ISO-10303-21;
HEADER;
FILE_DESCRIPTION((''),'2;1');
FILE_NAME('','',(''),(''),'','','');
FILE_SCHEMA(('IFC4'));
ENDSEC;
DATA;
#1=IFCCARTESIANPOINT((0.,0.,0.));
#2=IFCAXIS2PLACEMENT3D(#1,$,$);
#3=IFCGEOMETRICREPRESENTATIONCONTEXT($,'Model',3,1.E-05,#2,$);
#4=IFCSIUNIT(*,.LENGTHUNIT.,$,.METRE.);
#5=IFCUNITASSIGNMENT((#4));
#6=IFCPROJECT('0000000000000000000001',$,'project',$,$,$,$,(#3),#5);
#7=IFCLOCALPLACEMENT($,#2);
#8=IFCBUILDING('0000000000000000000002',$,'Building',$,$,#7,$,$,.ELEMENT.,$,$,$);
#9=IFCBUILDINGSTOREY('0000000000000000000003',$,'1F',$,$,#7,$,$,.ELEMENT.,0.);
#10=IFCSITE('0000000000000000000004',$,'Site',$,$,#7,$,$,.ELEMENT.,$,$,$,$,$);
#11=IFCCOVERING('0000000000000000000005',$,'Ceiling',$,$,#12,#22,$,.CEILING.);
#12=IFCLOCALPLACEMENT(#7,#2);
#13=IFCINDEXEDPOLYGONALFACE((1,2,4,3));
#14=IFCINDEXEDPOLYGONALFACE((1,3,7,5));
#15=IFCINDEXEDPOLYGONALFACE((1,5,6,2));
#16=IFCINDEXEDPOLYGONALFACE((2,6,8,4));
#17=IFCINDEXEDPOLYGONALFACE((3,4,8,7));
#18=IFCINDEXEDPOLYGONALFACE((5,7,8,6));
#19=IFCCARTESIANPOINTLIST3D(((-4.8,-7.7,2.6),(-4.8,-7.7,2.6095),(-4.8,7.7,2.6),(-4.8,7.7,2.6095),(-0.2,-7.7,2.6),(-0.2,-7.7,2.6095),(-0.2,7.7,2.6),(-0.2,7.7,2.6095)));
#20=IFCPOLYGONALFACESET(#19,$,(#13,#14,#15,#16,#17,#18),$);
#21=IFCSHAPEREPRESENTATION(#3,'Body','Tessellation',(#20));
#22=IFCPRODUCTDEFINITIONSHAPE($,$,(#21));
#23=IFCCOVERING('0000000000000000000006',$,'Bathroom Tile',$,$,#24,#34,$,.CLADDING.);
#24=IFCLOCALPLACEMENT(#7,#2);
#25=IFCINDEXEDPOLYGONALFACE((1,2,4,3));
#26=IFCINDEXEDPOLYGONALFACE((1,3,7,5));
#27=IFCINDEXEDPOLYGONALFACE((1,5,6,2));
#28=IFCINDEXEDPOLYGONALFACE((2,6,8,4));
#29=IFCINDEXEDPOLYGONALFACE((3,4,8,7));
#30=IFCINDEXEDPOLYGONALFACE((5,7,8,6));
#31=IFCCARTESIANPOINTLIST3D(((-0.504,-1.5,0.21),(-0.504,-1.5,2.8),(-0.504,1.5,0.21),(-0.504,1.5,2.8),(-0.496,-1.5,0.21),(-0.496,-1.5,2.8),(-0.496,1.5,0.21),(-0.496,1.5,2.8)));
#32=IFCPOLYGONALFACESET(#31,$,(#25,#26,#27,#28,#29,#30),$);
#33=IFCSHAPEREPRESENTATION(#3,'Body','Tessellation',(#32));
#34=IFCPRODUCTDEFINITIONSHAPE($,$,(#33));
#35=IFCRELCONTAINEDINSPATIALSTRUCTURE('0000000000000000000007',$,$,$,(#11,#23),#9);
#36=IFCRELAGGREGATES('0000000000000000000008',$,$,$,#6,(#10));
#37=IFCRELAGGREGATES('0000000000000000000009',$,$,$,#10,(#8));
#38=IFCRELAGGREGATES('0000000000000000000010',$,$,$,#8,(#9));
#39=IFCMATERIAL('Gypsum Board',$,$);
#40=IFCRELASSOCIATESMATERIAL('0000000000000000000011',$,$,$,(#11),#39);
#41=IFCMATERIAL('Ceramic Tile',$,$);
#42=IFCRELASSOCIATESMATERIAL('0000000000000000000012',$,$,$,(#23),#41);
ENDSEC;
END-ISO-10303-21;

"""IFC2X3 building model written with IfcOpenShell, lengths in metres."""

from ifc_helpers import new_model, si_unit, frame, origin, origin_2d, place, context, project, spatial, rectangle, extrude, material, element, save


model = new_model("IFC2X3")

# Units and contexts
model_context = context("Model", 3, precision=1e-05, world=origin())
ifc_project = project(units=[si_unit("LENGTHUNIT", "METRE")], contexts=[model_context])

# Site, building, storey
placement = place(None, origin())
site = spatial("IfcSite", under=ifc_project, at=placement, Name="Site", CompositionType="ELEMENT")
building = spatial("IfcBuilding", under=site, at=placement, Name="Building", CompositionType="ELEMENT")
storey = spatial("IfcBuildingStorey", under=building, at=placement, Name="1F", CompositionType="ELEMENT", Elevation=0.0)

# Shared definitions
ifc_material_1 = material(Name="Gypsum Board")

# Coverings
ifc_material_2 = material(Name="Ceramic Tile")
covering_1_placement = place(None, frame((-2.5, 0.0, 2.6)))
element("IfcCovering", 1, at=covering_1_placement, inside=storey, material=ifc_material_1, Name="Ceiling", PredefinedType="CEILING", context=model_context, shape_type="SweptSolid", body=[
    extrude(rectangle(XDim=4.6, YDim=15.4, at=origin_2d()), origin(), (0.0, 0.0, 1.0), 0.0095),
])
covering_2_placement = place(None, frame((-0.5, 0.0, 0.21)))
element("IfcCovering", 2, at=covering_2_placement, inside=storey, material=ifc_material_2, Name="Bathroom Tile", PredefinedType="CLADDING", context=model_context, shape_type="SweptSolid", body=[
    extrude(rectangle(XDim=0.008, YDim=3.0, at=origin_2d()), origin(), (0.0, 0.0, 1.0), 2.59),
])

save(model, "model.ifc")
